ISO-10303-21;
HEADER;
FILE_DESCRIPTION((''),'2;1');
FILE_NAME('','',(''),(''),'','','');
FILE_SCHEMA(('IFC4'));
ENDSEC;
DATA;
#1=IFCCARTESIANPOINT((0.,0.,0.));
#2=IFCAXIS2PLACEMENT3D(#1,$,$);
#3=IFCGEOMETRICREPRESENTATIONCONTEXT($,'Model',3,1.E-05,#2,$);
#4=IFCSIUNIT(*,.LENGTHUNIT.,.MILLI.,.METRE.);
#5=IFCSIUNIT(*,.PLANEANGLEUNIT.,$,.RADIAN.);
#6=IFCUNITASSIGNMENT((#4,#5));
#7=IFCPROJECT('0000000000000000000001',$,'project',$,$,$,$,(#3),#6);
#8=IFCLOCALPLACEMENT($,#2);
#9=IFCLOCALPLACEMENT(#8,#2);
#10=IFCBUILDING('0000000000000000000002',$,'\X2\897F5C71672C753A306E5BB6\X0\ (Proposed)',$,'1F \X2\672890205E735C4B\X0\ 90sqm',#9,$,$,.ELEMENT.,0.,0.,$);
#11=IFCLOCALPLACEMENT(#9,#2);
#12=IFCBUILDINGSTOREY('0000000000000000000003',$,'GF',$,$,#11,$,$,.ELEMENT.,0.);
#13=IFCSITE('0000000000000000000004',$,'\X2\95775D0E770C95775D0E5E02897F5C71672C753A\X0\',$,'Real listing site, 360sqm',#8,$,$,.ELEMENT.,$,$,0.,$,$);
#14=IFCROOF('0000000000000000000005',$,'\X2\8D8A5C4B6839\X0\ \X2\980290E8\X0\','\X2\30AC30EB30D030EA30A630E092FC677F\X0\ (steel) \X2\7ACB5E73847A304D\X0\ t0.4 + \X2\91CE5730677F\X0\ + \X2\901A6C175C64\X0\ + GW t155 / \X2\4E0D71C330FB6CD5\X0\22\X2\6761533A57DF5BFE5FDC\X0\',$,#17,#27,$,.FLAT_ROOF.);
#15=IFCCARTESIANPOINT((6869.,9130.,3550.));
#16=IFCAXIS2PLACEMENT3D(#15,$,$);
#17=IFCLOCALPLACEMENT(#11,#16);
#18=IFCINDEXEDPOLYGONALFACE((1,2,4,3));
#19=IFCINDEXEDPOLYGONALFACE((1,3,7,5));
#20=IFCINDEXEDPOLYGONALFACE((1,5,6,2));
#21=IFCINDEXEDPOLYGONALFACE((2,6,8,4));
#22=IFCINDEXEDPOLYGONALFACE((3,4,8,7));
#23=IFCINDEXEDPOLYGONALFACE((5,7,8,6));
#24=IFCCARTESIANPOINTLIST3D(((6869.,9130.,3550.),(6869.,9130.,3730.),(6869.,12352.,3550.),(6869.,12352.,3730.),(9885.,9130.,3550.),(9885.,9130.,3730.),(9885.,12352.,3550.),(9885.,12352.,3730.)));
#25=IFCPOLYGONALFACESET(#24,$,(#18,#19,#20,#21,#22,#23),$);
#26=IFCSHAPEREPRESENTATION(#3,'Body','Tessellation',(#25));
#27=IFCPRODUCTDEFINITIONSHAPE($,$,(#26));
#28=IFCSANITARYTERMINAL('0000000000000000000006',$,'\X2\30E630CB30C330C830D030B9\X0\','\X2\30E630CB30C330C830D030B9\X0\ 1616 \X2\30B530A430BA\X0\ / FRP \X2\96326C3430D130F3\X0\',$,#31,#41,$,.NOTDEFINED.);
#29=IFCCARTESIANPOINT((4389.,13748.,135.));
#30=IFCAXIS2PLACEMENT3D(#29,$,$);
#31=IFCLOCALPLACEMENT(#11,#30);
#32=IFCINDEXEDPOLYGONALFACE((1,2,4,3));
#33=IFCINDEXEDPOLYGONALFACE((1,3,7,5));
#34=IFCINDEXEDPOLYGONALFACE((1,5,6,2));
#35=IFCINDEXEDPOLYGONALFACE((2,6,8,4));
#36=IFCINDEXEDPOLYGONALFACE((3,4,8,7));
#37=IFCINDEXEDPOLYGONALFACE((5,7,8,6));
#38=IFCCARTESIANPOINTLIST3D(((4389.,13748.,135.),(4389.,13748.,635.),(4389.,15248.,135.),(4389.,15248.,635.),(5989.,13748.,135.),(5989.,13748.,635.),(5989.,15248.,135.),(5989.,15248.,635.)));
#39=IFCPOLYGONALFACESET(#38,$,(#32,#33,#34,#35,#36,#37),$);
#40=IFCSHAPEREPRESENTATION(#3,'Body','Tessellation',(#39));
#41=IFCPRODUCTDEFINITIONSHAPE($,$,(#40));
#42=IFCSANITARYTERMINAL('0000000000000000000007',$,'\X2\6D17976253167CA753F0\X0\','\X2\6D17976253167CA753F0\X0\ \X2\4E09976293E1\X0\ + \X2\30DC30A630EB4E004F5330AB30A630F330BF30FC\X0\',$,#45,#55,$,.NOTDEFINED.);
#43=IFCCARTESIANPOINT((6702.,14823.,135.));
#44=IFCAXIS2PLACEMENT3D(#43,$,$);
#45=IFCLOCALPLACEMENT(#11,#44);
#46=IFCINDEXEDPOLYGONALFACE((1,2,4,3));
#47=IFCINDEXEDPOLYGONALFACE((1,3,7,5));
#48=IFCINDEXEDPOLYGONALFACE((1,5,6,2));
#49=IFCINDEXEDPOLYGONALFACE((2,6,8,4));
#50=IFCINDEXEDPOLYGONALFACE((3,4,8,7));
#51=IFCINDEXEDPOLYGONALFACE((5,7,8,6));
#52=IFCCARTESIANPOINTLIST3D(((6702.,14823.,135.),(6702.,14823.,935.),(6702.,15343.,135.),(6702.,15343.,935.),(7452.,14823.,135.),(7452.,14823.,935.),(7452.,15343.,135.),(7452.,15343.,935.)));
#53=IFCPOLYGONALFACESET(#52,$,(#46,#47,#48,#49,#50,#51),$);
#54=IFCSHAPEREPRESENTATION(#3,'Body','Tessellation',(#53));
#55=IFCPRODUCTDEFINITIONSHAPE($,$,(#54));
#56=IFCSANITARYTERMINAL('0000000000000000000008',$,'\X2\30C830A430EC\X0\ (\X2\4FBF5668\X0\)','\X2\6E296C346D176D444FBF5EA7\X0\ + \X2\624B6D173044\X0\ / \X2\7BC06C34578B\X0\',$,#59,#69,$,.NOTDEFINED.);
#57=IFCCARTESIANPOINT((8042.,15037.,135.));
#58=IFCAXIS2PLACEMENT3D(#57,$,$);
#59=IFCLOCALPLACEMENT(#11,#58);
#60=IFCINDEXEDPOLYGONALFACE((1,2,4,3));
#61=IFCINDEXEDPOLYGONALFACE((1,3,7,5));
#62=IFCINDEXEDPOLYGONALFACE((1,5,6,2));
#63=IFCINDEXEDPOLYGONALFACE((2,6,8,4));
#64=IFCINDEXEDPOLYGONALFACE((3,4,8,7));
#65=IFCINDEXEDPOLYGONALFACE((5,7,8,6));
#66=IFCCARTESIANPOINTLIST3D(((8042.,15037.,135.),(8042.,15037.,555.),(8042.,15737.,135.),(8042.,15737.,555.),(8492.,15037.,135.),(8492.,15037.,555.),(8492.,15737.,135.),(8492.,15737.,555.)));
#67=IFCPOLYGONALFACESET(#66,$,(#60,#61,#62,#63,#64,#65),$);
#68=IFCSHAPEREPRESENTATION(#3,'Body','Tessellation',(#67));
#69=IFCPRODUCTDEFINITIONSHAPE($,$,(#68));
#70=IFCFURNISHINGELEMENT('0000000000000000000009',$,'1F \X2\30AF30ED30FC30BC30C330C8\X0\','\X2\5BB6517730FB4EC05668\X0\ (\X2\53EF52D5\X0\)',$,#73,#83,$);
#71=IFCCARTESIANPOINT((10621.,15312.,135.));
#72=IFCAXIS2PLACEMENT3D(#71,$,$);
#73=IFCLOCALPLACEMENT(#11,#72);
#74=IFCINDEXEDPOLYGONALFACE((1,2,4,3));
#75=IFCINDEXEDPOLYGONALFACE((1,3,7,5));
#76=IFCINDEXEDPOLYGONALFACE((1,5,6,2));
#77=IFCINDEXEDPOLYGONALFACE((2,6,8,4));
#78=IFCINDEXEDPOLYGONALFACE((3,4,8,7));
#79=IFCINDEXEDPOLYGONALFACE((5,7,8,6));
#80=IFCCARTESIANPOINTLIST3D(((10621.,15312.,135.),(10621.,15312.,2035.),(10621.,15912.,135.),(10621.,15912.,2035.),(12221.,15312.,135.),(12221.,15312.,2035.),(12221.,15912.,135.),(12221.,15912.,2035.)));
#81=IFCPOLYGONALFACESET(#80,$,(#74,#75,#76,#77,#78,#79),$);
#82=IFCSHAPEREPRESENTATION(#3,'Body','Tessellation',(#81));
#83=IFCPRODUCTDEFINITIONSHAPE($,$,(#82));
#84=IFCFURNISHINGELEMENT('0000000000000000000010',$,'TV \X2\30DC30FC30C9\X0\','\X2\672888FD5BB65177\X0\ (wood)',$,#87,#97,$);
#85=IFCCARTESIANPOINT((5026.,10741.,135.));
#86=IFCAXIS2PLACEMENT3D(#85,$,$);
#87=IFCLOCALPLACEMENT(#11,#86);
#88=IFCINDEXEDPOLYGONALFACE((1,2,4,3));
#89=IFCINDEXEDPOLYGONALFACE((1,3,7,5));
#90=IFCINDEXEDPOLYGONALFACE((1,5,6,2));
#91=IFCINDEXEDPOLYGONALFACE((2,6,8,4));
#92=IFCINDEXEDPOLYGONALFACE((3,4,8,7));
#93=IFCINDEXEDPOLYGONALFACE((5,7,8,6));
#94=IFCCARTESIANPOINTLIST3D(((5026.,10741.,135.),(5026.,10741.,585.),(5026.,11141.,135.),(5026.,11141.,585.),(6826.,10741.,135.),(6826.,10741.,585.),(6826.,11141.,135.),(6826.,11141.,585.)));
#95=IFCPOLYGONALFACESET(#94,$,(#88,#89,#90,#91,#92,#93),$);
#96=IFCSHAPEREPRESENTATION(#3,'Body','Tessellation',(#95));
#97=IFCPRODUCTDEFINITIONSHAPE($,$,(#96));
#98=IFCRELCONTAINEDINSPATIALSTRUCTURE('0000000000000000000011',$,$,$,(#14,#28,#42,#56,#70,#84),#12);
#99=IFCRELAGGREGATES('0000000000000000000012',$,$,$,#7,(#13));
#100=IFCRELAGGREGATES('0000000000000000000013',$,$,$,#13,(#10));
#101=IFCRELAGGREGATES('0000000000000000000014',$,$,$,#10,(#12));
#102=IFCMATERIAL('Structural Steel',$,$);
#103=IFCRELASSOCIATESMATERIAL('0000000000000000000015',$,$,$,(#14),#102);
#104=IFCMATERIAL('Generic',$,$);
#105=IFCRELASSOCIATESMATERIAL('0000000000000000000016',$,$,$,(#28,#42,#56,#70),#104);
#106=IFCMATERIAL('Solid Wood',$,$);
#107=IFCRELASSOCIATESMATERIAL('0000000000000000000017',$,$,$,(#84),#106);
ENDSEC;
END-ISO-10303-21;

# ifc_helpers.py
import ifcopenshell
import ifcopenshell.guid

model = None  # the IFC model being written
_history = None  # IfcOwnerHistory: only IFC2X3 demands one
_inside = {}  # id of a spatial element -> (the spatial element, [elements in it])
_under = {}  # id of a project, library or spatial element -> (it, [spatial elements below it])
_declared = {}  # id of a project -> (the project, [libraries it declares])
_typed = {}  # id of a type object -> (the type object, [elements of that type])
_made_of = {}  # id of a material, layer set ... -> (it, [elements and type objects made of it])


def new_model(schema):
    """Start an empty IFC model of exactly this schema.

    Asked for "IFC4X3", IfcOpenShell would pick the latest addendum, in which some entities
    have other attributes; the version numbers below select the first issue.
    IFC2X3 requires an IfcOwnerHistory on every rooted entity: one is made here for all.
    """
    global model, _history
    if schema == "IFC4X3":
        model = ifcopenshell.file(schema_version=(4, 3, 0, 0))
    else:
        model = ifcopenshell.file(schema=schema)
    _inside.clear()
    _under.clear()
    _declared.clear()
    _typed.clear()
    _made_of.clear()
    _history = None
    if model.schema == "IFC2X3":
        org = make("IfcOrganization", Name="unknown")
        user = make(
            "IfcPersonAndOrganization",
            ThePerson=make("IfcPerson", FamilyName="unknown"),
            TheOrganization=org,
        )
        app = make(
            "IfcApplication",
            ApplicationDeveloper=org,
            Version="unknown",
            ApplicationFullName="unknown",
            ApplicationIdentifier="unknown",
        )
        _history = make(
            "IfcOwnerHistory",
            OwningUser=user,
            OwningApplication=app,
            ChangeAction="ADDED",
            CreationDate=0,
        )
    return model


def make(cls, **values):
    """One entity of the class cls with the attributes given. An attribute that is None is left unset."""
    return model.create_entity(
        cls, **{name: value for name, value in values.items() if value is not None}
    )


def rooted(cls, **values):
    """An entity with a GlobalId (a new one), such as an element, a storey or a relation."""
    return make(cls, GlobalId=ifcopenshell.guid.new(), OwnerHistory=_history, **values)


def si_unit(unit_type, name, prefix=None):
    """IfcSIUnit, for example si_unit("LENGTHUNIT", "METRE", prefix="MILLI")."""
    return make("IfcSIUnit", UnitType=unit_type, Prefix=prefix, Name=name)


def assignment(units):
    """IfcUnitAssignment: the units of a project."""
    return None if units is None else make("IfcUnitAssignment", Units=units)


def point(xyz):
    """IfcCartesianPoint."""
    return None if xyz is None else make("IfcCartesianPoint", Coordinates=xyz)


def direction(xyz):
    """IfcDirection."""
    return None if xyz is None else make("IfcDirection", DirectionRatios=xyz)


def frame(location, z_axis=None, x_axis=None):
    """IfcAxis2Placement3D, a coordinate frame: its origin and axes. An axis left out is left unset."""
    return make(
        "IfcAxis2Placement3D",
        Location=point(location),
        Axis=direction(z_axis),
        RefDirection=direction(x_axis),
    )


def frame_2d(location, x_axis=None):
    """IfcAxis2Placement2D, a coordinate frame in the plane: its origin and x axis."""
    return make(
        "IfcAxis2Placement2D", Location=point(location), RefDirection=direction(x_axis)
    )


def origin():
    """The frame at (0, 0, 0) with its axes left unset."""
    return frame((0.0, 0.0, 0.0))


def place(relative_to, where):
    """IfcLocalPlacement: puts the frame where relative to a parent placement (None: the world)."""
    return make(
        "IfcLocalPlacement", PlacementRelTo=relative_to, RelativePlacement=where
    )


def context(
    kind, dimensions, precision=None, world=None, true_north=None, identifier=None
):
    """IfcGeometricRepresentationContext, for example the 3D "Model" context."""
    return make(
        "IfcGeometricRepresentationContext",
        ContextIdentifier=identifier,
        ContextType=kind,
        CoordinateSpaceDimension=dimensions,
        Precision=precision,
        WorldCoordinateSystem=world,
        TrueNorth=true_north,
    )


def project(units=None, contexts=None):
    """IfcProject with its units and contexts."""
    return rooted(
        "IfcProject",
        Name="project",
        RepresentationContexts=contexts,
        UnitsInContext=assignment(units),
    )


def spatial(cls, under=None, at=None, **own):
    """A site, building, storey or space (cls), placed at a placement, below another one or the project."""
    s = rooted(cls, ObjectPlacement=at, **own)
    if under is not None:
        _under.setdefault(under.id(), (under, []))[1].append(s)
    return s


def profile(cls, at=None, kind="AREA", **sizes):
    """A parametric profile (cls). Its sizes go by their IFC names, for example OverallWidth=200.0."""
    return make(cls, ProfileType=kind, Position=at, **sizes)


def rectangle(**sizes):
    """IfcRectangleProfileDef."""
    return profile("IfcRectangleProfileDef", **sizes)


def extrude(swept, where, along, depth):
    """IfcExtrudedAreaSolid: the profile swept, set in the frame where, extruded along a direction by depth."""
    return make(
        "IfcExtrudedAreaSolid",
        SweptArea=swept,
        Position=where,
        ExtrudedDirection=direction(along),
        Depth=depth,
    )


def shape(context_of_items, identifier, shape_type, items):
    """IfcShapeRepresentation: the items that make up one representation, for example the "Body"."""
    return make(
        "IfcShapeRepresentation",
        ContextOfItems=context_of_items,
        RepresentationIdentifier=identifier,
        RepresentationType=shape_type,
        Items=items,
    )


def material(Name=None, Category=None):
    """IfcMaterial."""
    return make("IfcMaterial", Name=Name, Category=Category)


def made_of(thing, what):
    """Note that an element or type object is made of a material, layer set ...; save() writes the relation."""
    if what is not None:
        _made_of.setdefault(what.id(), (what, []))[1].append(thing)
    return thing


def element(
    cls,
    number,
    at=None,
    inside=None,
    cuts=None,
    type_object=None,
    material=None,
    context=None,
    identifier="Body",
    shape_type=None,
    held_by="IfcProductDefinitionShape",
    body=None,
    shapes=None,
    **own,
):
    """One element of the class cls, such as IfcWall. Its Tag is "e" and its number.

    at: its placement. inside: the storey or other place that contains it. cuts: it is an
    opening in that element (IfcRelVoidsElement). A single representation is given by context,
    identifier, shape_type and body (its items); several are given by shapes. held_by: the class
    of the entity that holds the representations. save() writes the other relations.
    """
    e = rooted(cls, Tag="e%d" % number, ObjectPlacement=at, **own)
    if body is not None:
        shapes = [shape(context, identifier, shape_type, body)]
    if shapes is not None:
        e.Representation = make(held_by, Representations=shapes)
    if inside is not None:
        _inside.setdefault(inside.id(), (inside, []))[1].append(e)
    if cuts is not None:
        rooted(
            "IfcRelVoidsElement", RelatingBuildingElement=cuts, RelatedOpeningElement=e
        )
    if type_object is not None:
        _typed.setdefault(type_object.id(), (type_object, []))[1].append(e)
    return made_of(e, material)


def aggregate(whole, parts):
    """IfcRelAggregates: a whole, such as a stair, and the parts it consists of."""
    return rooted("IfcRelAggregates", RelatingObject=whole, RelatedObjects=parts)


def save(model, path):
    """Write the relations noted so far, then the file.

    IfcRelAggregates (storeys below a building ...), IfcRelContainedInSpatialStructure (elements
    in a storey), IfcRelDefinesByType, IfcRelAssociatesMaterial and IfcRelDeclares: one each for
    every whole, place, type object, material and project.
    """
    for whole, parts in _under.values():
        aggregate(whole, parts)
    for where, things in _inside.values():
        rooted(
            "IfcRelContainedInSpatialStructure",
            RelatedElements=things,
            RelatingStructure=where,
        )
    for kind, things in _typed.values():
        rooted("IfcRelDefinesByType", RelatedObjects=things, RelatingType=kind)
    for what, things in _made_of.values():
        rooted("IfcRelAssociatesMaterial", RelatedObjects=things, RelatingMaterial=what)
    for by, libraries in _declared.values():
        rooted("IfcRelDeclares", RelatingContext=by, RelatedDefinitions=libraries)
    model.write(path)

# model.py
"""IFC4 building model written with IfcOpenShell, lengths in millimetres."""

from ifc_helpers import new_model, si_unit, frame, frame_2d, origin, place, context, project, spatial, rectangle, extrude, material, element, save


model = new_model("IFC4")

# Units and contexts
model_context = context("Model", 3, precision=1e-05, world=origin())
ifc_project = project(units=[si_unit("LENGTHUNIT", "METRE", prefix="MILLI"), si_unit("PLANEANGLEUNIT", "RADIAN")], contexts=[model_context])

# Site, building, storey
site_placement = place(None, origin())
site = spatial("IfcSite", under=ifc_project, at=site_placement, Name="長崎県長崎市西山本町", ObjectType="Real listing site, 360sqm", CompositionType="ELEMENT", RefElevation=0.0)
building_placement = place(site_placement, origin())
building = spatial("IfcBuilding", under=site, at=building_placement, Name="西山本町の家 (Proposed)", ObjectType="1F 木造平屋 90sqm", CompositionType="ELEMENT", ElevationOfRefHeight=0.0, ElevationOfTerrain=0.0)
storey_placement = place(building_placement, origin())
storey = spatial("IfcBuildingStorey", under=building, at=storey_placement, Name="GF", CompositionType="ELEMENT", Elevation=0.0)

# Shared definitions
ifc_material_1 = material(Name="Solid Wood")

# Roof
ifc_material_2 = material(Name="Structural Steel")
roof_placement = place(storey_placement, frame((6869.0, 9130.0, 3550.0)))
element("IfcRoof", 1, at=roof_placement, inside=storey, material=ifc_material_2, Name="越屋根 頂部", Description="ガルバリウム鋼板 (steel) 立平葺き t0.4 + 野地板 + 通気層 + GW t155 / 不燃・法22条区域対応", PredefinedType="FLAT_ROOF", context=model_context, shape_type="SweptSolid", body=[
    extrude(rectangle(XDim=3016.0, YDim=3222.0, at=frame_2d((1508.0, 1611.0))), frame((6869.0, 9130.0, 3550.0)), (0.0, 0.0, 1.0), 180.0),
])

# Sanitary terminals
ifc_material_3 = material(Name="Generic")
sanitary_terminal_1_placement = place(storey_placement, frame((4389.0, 13748.0, 135.0)))
element("IfcSanitaryTerminal", 2, at=sanitary_terminal_1_placement, inside=storey, material=ifc_material_3, Name="ユニットバス", Description="ユニットバス 1616 サイズ / FRP 防水パン", PredefinedType="NOTDEFINED", context=model_context, shape_type="SweptSolid", body=[
    extrude(rectangle(XDim=1600.0, YDim=1500.0, at=frame_2d((800.0, 750.0))), frame((4389.0, 13748.0, 135.0)), (0.0, 0.0, 1.0), 500.0),
])
sanitary_terminal_2_placement = place(storey_placement, frame((6702.0, 14823.0, 135.0)))
element("IfcSanitaryTerminal", 3, at=sanitary_terminal_2_placement, inside=storey, material=ifc_material_3, Name="洗面化粧台", Description="洗面化粧台 三面鏡 + ボウル一体カウンター", PredefinedType="NOTDEFINED", context=model_context, shape_type="SweptSolid", body=[
    extrude(rectangle(XDim=750.0, YDim=520.0, at=frame_2d((375.0, 260.0))), frame((6702.0, 14823.0, 135.0)), (0.0, 0.0, 1.0), 800.0),
])
sanitary_terminal_3_placement = place(storey_placement, frame((8042.0, 15037.0, 135.0)))
element("IfcSanitaryTerminal", 4, at=sanitary_terminal_3_placement, inside=storey, material=ifc_material_3, Name="トイレ (便器)", Description="温水洗浄便座 + 手洗い / 節水型", PredefinedType="NOTDEFINED", context=model_context, shape_type="SweptSolid", body=[
    extrude(rectangle(XDim=450.0, YDim=700.0, at=frame_2d((225.0, 350.0))), frame((8042.0, 15037.0, 135.0)), (0.0, 0.0, 1.0), 420.0),
])

# Furnishing elements
furnishing_1_placement = place(storey_placement, frame((10621.0, 15312.0, 135.0)))
element("IfcFurnishingElement", 5, at=furnishing_1_placement, inside=storey, material=ifc_material_3, Name="1F クローゼット", Description="家具・什器 (可動)", context=model_context, shape_type="SweptSolid", body=[
    extrude(rectangle(XDim=1600.0, YDim=600.0, at=frame_2d((800.0, 300.0))), frame((10621.0, 15312.0, 135.0)), (0.0, 0.0, 1.0), 1900.0),
])
furnishing_2_placement = place(storey_placement, frame((5026.0, 10741.0, 135.0)))
element("IfcFurnishingElement", 6, at=furnishing_2_placement, inside=storey, material=ifc_material_1, Name="TV ボード", Description="木製家具 (wood)", context=model_context, shape_type="SweptSolid", body=[
    extrude(rectangle(XDim=1800.0, YDim=400.0, at=frame_2d((900.0, 200.0))), frame((5026.0, 10741.0, 135.0)), (0.0, 0.0, 1.0), 450.0),
])

save(model, "model.ifc")
